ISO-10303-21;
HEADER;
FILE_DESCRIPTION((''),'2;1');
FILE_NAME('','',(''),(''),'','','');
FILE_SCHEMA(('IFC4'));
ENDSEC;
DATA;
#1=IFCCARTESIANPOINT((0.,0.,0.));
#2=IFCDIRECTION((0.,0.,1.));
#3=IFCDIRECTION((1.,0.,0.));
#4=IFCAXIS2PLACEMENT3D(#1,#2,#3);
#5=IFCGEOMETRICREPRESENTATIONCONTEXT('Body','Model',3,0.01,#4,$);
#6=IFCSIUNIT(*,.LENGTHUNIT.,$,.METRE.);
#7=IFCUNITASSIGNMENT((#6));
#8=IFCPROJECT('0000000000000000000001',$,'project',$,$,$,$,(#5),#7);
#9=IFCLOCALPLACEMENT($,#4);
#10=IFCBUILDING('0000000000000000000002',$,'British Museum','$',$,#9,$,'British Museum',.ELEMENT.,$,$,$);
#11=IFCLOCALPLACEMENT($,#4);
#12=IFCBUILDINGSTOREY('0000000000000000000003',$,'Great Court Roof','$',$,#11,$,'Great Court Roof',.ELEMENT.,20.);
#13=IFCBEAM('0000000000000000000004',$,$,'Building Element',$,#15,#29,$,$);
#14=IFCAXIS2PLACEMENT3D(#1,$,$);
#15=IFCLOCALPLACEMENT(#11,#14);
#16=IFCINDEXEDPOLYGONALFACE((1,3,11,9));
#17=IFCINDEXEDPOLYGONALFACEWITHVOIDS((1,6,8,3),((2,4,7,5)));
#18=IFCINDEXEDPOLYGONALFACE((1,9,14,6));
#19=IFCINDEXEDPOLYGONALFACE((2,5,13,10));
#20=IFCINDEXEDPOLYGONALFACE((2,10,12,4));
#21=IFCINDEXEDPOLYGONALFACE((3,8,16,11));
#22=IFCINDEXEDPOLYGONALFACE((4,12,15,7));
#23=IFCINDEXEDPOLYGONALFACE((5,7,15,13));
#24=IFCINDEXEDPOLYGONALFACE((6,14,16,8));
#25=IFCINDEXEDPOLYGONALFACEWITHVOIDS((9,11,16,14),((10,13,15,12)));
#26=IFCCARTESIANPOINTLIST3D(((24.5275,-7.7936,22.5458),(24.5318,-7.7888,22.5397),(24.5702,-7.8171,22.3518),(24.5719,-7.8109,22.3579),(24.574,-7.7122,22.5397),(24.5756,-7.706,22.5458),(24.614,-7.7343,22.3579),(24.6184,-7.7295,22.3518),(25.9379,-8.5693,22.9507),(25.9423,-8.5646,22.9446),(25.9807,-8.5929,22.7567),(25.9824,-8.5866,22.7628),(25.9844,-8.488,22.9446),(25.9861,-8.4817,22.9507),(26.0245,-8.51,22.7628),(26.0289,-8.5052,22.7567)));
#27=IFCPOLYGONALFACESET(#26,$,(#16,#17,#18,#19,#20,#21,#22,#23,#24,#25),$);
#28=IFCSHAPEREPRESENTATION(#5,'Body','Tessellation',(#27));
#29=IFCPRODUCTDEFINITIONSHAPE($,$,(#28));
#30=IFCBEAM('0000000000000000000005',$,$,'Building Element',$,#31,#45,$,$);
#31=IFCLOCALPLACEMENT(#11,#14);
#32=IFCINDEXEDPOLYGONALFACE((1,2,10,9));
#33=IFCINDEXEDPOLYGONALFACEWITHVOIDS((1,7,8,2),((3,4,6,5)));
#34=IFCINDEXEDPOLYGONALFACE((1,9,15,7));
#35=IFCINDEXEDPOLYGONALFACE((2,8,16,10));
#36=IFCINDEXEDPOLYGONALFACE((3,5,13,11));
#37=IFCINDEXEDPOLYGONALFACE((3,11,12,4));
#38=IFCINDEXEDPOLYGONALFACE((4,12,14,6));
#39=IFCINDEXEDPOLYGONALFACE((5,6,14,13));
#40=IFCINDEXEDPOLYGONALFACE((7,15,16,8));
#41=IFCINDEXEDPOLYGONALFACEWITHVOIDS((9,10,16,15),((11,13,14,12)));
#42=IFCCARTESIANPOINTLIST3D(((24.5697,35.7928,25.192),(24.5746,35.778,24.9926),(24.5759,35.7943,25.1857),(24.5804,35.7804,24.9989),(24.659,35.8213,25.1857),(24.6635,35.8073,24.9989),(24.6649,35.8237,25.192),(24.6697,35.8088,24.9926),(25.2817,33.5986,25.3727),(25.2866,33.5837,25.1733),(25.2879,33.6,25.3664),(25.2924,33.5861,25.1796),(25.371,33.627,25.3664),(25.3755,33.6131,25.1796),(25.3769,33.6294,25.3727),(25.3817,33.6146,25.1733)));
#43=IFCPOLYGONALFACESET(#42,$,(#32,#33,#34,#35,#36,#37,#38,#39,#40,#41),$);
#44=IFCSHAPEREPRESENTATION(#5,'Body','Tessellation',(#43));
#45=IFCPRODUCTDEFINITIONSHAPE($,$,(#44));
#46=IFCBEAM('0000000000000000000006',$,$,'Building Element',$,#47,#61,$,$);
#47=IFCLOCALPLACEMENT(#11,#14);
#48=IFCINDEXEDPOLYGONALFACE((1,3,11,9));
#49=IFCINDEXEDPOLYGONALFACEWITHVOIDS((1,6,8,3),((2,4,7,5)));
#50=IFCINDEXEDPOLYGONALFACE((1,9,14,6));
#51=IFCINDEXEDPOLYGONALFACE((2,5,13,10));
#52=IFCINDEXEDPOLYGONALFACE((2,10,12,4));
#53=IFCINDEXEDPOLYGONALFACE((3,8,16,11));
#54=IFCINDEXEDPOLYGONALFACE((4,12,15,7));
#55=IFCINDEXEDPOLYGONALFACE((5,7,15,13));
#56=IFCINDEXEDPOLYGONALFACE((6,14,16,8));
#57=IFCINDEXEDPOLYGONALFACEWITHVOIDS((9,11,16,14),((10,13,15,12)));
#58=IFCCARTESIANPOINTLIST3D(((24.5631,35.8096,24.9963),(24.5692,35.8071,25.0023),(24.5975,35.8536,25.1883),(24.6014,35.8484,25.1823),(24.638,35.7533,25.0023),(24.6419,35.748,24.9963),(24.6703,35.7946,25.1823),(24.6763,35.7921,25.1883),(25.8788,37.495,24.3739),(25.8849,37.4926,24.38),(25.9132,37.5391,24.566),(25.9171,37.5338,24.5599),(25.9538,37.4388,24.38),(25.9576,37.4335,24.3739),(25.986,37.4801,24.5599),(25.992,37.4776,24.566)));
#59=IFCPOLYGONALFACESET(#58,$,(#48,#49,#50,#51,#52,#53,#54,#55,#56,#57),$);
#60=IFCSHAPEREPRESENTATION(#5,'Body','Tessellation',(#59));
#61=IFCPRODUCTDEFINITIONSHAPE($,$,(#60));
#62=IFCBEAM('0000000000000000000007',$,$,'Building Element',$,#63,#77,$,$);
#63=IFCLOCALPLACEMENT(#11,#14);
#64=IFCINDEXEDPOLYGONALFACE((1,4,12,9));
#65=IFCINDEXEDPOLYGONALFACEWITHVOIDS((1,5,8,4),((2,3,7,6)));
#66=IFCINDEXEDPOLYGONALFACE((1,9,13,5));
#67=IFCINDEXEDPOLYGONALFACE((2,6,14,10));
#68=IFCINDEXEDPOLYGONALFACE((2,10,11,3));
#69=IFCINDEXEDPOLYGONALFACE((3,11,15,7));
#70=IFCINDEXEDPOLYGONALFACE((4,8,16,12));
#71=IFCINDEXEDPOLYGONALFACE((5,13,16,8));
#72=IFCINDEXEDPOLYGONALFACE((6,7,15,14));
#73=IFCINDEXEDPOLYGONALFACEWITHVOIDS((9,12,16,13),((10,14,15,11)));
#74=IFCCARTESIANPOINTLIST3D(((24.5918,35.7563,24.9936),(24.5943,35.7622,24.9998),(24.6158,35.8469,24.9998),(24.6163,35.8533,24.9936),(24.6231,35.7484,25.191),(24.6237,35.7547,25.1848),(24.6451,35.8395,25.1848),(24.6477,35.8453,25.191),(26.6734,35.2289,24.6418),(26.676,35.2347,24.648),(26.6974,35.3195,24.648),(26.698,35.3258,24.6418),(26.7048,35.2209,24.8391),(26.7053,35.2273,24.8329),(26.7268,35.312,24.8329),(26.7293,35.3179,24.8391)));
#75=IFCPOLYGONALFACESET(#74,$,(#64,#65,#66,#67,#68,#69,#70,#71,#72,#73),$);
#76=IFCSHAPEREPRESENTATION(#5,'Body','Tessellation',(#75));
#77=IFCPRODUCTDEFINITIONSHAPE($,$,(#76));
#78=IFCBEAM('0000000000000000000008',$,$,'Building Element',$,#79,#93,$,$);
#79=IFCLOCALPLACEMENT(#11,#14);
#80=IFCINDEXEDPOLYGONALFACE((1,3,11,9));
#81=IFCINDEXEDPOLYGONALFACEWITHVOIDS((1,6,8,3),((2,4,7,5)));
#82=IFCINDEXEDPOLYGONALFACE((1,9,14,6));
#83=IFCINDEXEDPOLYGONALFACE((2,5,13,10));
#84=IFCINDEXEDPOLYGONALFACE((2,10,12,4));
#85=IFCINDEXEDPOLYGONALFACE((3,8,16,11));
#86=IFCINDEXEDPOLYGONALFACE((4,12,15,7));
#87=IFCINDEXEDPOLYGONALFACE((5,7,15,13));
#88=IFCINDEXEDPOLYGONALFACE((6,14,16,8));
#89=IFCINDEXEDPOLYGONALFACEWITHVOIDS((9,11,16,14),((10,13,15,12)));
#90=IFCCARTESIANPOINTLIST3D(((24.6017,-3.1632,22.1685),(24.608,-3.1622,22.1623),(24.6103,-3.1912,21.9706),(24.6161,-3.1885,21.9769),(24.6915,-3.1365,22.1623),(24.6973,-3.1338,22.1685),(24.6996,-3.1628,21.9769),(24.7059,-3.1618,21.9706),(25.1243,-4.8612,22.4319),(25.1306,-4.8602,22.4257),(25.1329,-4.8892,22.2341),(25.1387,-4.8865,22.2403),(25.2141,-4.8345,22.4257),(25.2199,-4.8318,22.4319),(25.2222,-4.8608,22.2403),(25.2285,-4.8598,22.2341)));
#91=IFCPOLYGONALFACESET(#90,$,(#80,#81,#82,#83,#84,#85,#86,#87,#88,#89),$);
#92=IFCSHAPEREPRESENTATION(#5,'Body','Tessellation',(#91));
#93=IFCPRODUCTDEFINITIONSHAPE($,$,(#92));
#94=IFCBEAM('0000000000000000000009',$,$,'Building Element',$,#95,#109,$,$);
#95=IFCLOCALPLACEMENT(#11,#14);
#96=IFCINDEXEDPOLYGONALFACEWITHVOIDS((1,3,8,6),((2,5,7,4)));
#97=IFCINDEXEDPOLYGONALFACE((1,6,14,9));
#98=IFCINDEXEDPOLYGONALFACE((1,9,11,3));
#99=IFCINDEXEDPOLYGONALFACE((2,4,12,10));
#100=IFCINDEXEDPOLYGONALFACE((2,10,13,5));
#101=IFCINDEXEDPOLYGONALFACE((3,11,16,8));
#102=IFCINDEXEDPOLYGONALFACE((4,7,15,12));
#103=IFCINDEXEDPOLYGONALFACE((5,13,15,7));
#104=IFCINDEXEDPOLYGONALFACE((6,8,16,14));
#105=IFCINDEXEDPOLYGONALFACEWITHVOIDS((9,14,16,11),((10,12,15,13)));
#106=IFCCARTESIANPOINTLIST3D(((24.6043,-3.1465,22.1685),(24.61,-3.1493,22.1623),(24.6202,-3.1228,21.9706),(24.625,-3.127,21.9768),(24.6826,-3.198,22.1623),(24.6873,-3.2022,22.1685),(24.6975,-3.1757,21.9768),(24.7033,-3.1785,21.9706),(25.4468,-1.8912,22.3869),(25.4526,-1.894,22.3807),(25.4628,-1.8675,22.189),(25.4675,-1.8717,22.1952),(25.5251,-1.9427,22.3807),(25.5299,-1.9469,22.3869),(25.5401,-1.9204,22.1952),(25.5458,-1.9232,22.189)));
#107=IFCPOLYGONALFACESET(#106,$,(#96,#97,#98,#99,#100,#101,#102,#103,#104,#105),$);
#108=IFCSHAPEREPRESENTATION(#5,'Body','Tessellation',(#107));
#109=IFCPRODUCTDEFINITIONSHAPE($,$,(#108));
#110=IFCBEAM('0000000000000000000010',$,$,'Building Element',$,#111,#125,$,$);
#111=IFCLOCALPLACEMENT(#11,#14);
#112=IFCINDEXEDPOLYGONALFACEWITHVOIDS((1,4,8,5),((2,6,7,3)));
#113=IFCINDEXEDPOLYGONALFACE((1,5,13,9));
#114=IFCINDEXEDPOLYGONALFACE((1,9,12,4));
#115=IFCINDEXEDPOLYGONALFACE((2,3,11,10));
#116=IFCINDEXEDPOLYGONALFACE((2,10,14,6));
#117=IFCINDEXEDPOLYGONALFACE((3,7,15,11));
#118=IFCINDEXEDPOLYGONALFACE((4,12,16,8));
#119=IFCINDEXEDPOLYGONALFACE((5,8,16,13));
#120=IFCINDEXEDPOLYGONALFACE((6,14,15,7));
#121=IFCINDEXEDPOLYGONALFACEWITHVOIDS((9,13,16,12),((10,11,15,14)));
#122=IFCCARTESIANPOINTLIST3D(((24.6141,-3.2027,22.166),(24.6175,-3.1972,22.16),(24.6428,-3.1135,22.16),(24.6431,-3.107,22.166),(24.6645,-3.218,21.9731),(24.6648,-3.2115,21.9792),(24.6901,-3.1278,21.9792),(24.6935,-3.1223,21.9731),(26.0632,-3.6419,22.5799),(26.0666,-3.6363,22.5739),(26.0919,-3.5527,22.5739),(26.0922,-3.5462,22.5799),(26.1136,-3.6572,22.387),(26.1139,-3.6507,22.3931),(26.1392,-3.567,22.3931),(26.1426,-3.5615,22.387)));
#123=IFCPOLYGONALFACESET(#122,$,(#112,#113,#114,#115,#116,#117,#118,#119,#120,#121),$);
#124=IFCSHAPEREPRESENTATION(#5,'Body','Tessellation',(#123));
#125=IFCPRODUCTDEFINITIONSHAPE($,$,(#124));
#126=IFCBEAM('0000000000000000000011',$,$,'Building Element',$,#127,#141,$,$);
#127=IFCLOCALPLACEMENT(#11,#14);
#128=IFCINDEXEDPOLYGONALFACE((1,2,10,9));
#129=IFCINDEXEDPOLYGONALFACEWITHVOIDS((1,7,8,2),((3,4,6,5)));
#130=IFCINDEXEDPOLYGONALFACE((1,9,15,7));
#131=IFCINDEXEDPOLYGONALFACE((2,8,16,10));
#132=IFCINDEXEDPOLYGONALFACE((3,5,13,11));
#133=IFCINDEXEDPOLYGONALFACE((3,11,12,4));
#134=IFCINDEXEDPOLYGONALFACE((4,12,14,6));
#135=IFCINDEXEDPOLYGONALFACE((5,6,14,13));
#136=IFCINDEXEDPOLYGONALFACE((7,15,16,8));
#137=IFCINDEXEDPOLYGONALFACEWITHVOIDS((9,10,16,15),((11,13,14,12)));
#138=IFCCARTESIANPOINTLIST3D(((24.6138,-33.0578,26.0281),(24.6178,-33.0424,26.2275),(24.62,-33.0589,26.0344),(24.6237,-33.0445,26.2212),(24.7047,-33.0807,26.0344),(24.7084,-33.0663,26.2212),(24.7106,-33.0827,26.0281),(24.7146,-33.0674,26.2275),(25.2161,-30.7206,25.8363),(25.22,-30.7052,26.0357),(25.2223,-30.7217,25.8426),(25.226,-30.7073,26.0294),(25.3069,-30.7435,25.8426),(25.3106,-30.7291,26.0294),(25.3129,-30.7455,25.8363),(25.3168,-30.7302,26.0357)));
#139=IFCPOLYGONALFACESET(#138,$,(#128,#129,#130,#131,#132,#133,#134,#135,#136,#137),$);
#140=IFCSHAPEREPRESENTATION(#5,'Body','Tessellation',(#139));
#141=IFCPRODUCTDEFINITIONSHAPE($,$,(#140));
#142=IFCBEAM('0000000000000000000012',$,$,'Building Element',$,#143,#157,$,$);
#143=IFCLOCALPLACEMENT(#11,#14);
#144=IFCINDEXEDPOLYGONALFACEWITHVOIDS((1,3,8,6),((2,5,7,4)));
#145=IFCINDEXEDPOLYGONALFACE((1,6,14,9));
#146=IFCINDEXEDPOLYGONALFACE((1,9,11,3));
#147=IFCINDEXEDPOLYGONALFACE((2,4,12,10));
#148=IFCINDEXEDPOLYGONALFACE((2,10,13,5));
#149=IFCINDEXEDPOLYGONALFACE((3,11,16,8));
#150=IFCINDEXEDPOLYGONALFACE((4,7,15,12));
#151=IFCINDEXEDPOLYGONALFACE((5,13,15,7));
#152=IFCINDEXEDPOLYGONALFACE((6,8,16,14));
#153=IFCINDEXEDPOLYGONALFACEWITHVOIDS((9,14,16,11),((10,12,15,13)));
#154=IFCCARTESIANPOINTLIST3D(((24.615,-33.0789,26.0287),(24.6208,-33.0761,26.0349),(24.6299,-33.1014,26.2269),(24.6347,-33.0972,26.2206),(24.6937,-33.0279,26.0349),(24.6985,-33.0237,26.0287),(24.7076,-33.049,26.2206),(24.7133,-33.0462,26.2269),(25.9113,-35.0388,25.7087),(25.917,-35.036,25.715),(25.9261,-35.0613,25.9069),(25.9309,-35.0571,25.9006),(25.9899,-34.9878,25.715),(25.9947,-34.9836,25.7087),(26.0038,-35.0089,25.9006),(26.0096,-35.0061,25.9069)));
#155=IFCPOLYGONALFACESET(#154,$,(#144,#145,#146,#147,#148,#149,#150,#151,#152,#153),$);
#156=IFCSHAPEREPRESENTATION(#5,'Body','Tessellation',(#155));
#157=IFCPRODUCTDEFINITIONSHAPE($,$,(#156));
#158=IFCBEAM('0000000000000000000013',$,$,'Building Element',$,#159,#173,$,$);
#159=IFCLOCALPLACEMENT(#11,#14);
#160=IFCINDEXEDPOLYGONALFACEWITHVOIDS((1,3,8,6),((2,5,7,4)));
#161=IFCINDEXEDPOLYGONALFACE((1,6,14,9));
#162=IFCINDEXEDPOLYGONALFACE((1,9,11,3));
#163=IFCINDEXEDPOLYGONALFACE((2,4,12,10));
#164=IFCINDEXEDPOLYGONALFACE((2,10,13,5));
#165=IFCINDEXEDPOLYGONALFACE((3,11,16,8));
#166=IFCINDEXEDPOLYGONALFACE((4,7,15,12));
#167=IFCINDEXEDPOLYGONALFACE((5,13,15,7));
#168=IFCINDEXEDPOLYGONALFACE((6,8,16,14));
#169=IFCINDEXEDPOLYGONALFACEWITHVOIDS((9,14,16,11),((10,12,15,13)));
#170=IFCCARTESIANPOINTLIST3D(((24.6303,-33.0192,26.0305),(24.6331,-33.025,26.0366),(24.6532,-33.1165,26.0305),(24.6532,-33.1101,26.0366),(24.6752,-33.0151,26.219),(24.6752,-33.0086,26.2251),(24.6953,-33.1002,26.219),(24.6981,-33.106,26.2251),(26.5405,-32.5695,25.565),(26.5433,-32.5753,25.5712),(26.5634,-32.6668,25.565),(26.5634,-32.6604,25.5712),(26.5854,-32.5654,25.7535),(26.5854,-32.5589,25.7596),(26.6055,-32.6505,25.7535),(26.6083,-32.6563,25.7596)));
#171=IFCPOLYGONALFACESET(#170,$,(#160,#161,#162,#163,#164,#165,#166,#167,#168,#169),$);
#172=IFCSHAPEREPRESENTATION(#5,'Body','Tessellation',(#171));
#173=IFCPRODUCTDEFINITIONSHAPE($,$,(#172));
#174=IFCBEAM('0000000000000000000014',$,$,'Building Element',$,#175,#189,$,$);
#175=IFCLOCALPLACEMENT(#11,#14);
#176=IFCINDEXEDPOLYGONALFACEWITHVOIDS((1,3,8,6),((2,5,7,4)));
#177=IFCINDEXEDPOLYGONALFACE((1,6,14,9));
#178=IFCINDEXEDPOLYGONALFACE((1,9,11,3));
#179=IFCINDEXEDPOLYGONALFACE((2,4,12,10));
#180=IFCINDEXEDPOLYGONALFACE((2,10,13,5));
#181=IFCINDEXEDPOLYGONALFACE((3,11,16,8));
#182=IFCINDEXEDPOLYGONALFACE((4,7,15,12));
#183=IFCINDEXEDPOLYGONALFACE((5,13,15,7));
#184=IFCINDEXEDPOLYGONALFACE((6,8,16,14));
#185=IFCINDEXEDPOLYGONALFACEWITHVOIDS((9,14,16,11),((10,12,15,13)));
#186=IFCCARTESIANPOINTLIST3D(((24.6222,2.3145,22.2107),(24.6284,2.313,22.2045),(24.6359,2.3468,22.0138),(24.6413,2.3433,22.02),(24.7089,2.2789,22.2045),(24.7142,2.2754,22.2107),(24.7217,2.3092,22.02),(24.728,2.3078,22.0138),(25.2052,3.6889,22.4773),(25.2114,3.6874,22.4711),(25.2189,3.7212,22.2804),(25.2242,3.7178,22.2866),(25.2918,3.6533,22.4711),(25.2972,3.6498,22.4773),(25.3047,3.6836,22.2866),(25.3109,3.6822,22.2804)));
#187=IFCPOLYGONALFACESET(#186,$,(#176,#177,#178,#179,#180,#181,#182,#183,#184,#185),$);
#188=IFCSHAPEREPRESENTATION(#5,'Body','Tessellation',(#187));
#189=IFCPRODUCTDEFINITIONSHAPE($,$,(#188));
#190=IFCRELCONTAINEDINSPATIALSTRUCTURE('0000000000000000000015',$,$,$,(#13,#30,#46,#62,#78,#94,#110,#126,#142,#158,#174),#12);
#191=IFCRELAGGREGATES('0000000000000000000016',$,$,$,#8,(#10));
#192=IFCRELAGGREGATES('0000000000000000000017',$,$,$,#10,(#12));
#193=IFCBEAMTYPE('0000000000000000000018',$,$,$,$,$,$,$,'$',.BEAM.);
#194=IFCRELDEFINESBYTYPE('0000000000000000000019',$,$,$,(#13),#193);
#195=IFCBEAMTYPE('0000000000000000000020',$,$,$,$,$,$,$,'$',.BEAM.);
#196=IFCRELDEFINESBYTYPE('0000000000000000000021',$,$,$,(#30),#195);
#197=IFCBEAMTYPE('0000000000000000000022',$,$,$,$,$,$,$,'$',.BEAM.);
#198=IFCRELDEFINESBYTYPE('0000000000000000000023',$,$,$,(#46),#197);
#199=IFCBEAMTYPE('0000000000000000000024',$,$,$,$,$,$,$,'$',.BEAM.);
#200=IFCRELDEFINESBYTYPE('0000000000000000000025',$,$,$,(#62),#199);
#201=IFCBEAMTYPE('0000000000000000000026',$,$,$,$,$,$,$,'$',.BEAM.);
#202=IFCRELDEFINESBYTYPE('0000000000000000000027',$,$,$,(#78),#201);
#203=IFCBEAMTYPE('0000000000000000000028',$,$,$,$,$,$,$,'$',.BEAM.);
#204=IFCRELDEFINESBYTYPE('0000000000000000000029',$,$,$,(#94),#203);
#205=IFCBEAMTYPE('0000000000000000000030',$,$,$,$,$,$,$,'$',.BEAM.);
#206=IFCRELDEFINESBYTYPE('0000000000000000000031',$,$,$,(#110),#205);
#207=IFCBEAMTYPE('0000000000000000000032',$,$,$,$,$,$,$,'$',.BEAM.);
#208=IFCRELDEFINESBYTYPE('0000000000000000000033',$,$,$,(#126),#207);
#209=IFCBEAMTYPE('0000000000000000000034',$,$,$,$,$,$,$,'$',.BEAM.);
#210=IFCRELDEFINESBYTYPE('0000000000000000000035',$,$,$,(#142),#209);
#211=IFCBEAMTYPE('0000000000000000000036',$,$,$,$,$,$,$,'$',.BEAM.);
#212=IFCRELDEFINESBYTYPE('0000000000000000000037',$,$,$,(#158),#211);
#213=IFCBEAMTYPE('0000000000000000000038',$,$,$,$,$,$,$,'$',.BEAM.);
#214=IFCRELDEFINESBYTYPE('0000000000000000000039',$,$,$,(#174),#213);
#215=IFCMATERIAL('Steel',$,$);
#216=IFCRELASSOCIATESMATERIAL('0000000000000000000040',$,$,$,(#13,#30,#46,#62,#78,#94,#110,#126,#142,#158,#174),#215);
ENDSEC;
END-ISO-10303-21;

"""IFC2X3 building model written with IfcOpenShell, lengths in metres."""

from ifc_helpers import new_model, si_unit, frame, origin_with_axes, origin_2d, place, context, project, spatial, hollow_rectangle, extrude, material, type_object, element, save


model = new_model("IFC2X3")

# Units and contexts
model_context = context("Model", 3, precision=0.01, world=origin_with_axes(), identifier="Body")
ifc_project = project(units=[si_unit("LENGTHUNIT", "METRE")], contexts=[model_context])

# Building, storey
building_placement = place(None, origin_with_axes())
building = spatial("IfcBuilding", under=ifc_project, at=building_placement, Name="British Museum", Description="$", LongName="British Museum", CompositionType="ELEMENT")
storey_placement = place(None, origin_with_axes())
storey = spatial("IfcBuildingStorey", under=building, at=storey_placement, Name="Great Court Roof", Description="$", LongName="Great Court Roof", CompositionType="ELEMENT", Elevation=20.0)

# Beams
ifc_material = material(Name="Steel")
beam_type_1 = type_object("IfcBeamType", ElementType="$", PredefinedType="BEAM")
beam_1_placement = place(None, origin_with_axes())
element("IfcBeam", 1, at=beam_1_placement, inside=storey, type_object=beam_type_1, material=ifc_material, Description="Building Element", context=model_context, shape_type="SweptSolid", body=[
    extrude(hollow_rectangle(XDim=0.1, YDim=0.2, WallThickness=0.0063, InnerFilletRadius=-0.0063, OuterFilletRadius=0.0, at=origin_2d()), frame((24.5729, -7.7616, 22.4488), z_axis=(0.849755, -0.467342, 0.243941), x_axis=(0.481901, 0.876226, 0.0)), (0.0, 0.0, 1.0), 1.6599),
])
beam_type_2 = type_object("IfcBeamType", ElementType="$", PredefinedType="BEAM")
beam_2_placement = place(None, origin_with_axes())
element("IfcBeam", 2, at=beam_2_placement, inside=storey, type_object=beam_type_2, material=ifc_material, Description="Building Element", context=model_context, shape_type="SweptSolid", body=[
    extrude(hollow_rectangle(XDim=0.1, YDim=0.2, WallThickness=0.0063, InnerFilletRadius=-0.0063, OuterFilletRadius=0.0, at=origin_2d()), frame((24.6197, 35.8008, 25.0923), z_axis=(0.307698, -0.948272, 0.078112), x_axis=(0.951179, 0.308641, 0.0)), (0.0, 0.0, 1.0), 2.3139),
])
beam_type_3 = type_object("IfcBeamType", ElementType="$", PredefinedType="BEAM")
beam_3_placement = place(None, origin_with_axes())
element("IfcBeam", 3, at=beam_3_placement, inside=storey, type_object=beam_type_3, material=ifc_material, Description="Building Element", context=model_context, shape_type="SweptSolid", body=[
    extrude(hollow_rectangle(XDim=0.1, YDim=0.2, WallThickness=0.0063, InnerFilletRadius=-0.0063, OuterFilletRadius=0.0, at=origin_2d()), frame((24.6197, 35.8008, 25.0923), z_axis=(0.590817, 0.756861, -0.279456), x_axis=(-0.788267, 0.615333, 0.0)), (0.0, 0.0, 1.0), 2.2269),
])
beam_type_4 = type_object("IfcBeamType", ElementType="$", PredefinedType="BEAM")
beam_4_placement = place(None, origin_with_axes())
element("IfcBeam", 4, at=beam_4_placement, inside=storey, type_object=beam_type_4, material=ifc_material, Description="Building Element", context=model_context, shape_type="SweptSolid", body=[
    extrude(hollow_rectangle(XDim=0.1, YDim=0.2, WallThickness=0.0063, InnerFilletRadius=-0.0063, OuterFilletRadius=0.0, at=origin_2d()), frame((24.6197, 35.8008, 25.0923), z_axis=(0.956614, -0.242383, -0.161681), x_axis=(0.245614, 0.969368, 0.0)), (0.0, 0.0, 1.0), 2.1761),
])
beam_type_5 = type_object("IfcBeamType", ElementType="$", PredefinedType="BEAM")
beam_5_placement = place(None, origin_with_axes())
element("IfcBeam", 5, at=beam_5_placement, inside=storey, type_object=beam_type_5, material=ifc_material, Description="Building Element", context=model_context, shape_type="SweptSolid", body=[
    extrude(hollow_rectangle(XDim=0.1, YDim=0.2, WallThickness=0.0063, InnerFilletRadius=-0.0063, OuterFilletRadius=0.0, at=origin_2d()), frame((24.6538, -3.1625, 22.0696), z_axis=(0.290988, -0.945414, 0.146693), x_axis=(0.955753, 0.294171, 0.0)), (0.0, 0.0, 1.0), 1.796),
])
beam_type_6 = type_object("IfcBeamType", ElementType="$", PredefinedType="BEAM")
beam_6_placement = place(None, origin_with_axes())
element("IfcBeam", 6, at=beam_6_placement, inside=storey, type_object=beam_type_6, material=ifc_material, Description="Building Element", context=model_context, shape_type="SweptSolid", body=[
    extrude(hollow_rectangle(XDim=0.1, YDim=0.2, WallThickness=0.0063, InnerFilletRadius=-0.0063, OuterFilletRadius=0.0, at=origin_2d()), frame((24.6538, -3.1625, 22.0696), z_axis=(0.551561, 0.82179, 0.142978), x_axis=(-0.830321, 0.557286, 0.0)), (0.0, 0.0, 1.0), 1.5275),
])
beam_type_7 = type_object("IfcBeamType", ElementType="$", PredefinedType="BEAM")
beam_7_placement = place(None, origin_with_axes())
element("IfcBeam", 7, at=beam_7_placement, inside=storey, type_object=beam_type_7, material=ifc_material, Description="Building Element", context=model_context, shape_type="SweptSolid", body=[
    extrude(hollow_rectangle(XDim=0.1, YDim=0.2, WallThickness=0.0063, InnerFilletRadius=-0.0063, OuterFilletRadius=0.0, at=origin_2d()), frame((24.6538, -3.1625, 22.0696), z_axis=(0.923143, -0.279782, 0.263684), x_axis=(0.290047, 0.957012, 0.0)), (0.0, 0.0, 1.0), 1.5698),
])
beam_type_8 = type_object("IfcBeamType", ElementType="$", PredefinedType="BEAM")
beam_8_placement = place(None, origin_with_axes())
element("IfcBeam", 8, at=beam_8_placement, inside=storey, type_object=beam_type_8, material=ifc_material, Description="Building Element", context=model_context, shape_type="SweptSolid", body=[
    extrude(hollow_rectangle(XDim=0.1, YDim=0.2, WallThickness=0.0063, InnerFilletRadius=-0.0063, OuterFilletRadius=0.0, at=origin_2d()), frame((24.6642, -33.0626, 26.1278), z_axis=(0.248749, 0.965324, -0.079208), x_axis=(-0.968366, 0.249533, 0.0)), (0.0, 0.0, 1.0), 2.4211),
])
beam_type_9 = type_object("IfcBeamType", ElementType="$", PredefinedType="BEAM")
beam_9_placement = place(None, origin_with_axes())
element("IfcBeam", 9, at=beam_9_placement, inside=storey, type_object=beam_type_9, material=ifc_material, Description="Building Element", context=model_context, shape_type="SweptSolid", body=[
    extrude(hollow_rectangle(XDim=0.1, YDim=0.2, WallThickness=0.0063, InnerFilletRadius=-0.0063, OuterFilletRadius=0.0, at=origin_2d()), frame((24.6642, -33.0626, 26.1278), z_axis=(0.546592, -0.826456, -0.134936), x_axis=(0.834084, 0.551637, 0.0)), (0.0, 0.0, 1.0), 2.3714),
])
beam_type_10 = type_object("IfcBeamType", ElementType="$", PredefinedType="BEAM")
beam_10_placement = place(None, origin_with_axes())
element("IfcBeam", 10, at=beam_10_placement, inside=storey, type_object=beam_type_10, material=ifc_material, Description="Building Element", context=model_context, shape_type="SweptSolid", body=[
    extrude(hollow_rectangle(XDim=0.1, YDim=0.2, WallThickness=0.0063, InnerFilletRadius=-0.0063, OuterFilletRadius=0.0, at=origin_2d()), frame((24.6642, -33.0626, 26.1278), z_axis=(0.947114, 0.222962, -0.230786), x_axis=(-0.229148, 0.973392, 0.0)), (0.0, 0.0, 1.0), 2.0169),
])
beam_type_11 = type_object("IfcBeamType", ElementType="$", PredefinedType="BEAM")
beam_11_placement = place(None, origin_with_axes())
element("IfcBeam", 11, at=beam_11_placement, inside=storey, type_object=beam_type_11, material=ifc_material, Description="Building Element", context=model_context, shape_type="SweptSolid", body=[
    extrude(hollow_rectangle(XDim=0.1, YDim=0.2, WallThickness=0.0063, InnerFilletRadius=-0.0063, OuterFilletRadius=0.0, at=origin_2d()), frame((24.6751, 2.3111, 22.1122), z_axis=(0.384416, 0.906264, 0.175812), x_axis=(-0.920604, 0.390498, 0.0)), (0.0, 0.0, 1.0), 1.5166),
])

save(model, "model.ifc")
